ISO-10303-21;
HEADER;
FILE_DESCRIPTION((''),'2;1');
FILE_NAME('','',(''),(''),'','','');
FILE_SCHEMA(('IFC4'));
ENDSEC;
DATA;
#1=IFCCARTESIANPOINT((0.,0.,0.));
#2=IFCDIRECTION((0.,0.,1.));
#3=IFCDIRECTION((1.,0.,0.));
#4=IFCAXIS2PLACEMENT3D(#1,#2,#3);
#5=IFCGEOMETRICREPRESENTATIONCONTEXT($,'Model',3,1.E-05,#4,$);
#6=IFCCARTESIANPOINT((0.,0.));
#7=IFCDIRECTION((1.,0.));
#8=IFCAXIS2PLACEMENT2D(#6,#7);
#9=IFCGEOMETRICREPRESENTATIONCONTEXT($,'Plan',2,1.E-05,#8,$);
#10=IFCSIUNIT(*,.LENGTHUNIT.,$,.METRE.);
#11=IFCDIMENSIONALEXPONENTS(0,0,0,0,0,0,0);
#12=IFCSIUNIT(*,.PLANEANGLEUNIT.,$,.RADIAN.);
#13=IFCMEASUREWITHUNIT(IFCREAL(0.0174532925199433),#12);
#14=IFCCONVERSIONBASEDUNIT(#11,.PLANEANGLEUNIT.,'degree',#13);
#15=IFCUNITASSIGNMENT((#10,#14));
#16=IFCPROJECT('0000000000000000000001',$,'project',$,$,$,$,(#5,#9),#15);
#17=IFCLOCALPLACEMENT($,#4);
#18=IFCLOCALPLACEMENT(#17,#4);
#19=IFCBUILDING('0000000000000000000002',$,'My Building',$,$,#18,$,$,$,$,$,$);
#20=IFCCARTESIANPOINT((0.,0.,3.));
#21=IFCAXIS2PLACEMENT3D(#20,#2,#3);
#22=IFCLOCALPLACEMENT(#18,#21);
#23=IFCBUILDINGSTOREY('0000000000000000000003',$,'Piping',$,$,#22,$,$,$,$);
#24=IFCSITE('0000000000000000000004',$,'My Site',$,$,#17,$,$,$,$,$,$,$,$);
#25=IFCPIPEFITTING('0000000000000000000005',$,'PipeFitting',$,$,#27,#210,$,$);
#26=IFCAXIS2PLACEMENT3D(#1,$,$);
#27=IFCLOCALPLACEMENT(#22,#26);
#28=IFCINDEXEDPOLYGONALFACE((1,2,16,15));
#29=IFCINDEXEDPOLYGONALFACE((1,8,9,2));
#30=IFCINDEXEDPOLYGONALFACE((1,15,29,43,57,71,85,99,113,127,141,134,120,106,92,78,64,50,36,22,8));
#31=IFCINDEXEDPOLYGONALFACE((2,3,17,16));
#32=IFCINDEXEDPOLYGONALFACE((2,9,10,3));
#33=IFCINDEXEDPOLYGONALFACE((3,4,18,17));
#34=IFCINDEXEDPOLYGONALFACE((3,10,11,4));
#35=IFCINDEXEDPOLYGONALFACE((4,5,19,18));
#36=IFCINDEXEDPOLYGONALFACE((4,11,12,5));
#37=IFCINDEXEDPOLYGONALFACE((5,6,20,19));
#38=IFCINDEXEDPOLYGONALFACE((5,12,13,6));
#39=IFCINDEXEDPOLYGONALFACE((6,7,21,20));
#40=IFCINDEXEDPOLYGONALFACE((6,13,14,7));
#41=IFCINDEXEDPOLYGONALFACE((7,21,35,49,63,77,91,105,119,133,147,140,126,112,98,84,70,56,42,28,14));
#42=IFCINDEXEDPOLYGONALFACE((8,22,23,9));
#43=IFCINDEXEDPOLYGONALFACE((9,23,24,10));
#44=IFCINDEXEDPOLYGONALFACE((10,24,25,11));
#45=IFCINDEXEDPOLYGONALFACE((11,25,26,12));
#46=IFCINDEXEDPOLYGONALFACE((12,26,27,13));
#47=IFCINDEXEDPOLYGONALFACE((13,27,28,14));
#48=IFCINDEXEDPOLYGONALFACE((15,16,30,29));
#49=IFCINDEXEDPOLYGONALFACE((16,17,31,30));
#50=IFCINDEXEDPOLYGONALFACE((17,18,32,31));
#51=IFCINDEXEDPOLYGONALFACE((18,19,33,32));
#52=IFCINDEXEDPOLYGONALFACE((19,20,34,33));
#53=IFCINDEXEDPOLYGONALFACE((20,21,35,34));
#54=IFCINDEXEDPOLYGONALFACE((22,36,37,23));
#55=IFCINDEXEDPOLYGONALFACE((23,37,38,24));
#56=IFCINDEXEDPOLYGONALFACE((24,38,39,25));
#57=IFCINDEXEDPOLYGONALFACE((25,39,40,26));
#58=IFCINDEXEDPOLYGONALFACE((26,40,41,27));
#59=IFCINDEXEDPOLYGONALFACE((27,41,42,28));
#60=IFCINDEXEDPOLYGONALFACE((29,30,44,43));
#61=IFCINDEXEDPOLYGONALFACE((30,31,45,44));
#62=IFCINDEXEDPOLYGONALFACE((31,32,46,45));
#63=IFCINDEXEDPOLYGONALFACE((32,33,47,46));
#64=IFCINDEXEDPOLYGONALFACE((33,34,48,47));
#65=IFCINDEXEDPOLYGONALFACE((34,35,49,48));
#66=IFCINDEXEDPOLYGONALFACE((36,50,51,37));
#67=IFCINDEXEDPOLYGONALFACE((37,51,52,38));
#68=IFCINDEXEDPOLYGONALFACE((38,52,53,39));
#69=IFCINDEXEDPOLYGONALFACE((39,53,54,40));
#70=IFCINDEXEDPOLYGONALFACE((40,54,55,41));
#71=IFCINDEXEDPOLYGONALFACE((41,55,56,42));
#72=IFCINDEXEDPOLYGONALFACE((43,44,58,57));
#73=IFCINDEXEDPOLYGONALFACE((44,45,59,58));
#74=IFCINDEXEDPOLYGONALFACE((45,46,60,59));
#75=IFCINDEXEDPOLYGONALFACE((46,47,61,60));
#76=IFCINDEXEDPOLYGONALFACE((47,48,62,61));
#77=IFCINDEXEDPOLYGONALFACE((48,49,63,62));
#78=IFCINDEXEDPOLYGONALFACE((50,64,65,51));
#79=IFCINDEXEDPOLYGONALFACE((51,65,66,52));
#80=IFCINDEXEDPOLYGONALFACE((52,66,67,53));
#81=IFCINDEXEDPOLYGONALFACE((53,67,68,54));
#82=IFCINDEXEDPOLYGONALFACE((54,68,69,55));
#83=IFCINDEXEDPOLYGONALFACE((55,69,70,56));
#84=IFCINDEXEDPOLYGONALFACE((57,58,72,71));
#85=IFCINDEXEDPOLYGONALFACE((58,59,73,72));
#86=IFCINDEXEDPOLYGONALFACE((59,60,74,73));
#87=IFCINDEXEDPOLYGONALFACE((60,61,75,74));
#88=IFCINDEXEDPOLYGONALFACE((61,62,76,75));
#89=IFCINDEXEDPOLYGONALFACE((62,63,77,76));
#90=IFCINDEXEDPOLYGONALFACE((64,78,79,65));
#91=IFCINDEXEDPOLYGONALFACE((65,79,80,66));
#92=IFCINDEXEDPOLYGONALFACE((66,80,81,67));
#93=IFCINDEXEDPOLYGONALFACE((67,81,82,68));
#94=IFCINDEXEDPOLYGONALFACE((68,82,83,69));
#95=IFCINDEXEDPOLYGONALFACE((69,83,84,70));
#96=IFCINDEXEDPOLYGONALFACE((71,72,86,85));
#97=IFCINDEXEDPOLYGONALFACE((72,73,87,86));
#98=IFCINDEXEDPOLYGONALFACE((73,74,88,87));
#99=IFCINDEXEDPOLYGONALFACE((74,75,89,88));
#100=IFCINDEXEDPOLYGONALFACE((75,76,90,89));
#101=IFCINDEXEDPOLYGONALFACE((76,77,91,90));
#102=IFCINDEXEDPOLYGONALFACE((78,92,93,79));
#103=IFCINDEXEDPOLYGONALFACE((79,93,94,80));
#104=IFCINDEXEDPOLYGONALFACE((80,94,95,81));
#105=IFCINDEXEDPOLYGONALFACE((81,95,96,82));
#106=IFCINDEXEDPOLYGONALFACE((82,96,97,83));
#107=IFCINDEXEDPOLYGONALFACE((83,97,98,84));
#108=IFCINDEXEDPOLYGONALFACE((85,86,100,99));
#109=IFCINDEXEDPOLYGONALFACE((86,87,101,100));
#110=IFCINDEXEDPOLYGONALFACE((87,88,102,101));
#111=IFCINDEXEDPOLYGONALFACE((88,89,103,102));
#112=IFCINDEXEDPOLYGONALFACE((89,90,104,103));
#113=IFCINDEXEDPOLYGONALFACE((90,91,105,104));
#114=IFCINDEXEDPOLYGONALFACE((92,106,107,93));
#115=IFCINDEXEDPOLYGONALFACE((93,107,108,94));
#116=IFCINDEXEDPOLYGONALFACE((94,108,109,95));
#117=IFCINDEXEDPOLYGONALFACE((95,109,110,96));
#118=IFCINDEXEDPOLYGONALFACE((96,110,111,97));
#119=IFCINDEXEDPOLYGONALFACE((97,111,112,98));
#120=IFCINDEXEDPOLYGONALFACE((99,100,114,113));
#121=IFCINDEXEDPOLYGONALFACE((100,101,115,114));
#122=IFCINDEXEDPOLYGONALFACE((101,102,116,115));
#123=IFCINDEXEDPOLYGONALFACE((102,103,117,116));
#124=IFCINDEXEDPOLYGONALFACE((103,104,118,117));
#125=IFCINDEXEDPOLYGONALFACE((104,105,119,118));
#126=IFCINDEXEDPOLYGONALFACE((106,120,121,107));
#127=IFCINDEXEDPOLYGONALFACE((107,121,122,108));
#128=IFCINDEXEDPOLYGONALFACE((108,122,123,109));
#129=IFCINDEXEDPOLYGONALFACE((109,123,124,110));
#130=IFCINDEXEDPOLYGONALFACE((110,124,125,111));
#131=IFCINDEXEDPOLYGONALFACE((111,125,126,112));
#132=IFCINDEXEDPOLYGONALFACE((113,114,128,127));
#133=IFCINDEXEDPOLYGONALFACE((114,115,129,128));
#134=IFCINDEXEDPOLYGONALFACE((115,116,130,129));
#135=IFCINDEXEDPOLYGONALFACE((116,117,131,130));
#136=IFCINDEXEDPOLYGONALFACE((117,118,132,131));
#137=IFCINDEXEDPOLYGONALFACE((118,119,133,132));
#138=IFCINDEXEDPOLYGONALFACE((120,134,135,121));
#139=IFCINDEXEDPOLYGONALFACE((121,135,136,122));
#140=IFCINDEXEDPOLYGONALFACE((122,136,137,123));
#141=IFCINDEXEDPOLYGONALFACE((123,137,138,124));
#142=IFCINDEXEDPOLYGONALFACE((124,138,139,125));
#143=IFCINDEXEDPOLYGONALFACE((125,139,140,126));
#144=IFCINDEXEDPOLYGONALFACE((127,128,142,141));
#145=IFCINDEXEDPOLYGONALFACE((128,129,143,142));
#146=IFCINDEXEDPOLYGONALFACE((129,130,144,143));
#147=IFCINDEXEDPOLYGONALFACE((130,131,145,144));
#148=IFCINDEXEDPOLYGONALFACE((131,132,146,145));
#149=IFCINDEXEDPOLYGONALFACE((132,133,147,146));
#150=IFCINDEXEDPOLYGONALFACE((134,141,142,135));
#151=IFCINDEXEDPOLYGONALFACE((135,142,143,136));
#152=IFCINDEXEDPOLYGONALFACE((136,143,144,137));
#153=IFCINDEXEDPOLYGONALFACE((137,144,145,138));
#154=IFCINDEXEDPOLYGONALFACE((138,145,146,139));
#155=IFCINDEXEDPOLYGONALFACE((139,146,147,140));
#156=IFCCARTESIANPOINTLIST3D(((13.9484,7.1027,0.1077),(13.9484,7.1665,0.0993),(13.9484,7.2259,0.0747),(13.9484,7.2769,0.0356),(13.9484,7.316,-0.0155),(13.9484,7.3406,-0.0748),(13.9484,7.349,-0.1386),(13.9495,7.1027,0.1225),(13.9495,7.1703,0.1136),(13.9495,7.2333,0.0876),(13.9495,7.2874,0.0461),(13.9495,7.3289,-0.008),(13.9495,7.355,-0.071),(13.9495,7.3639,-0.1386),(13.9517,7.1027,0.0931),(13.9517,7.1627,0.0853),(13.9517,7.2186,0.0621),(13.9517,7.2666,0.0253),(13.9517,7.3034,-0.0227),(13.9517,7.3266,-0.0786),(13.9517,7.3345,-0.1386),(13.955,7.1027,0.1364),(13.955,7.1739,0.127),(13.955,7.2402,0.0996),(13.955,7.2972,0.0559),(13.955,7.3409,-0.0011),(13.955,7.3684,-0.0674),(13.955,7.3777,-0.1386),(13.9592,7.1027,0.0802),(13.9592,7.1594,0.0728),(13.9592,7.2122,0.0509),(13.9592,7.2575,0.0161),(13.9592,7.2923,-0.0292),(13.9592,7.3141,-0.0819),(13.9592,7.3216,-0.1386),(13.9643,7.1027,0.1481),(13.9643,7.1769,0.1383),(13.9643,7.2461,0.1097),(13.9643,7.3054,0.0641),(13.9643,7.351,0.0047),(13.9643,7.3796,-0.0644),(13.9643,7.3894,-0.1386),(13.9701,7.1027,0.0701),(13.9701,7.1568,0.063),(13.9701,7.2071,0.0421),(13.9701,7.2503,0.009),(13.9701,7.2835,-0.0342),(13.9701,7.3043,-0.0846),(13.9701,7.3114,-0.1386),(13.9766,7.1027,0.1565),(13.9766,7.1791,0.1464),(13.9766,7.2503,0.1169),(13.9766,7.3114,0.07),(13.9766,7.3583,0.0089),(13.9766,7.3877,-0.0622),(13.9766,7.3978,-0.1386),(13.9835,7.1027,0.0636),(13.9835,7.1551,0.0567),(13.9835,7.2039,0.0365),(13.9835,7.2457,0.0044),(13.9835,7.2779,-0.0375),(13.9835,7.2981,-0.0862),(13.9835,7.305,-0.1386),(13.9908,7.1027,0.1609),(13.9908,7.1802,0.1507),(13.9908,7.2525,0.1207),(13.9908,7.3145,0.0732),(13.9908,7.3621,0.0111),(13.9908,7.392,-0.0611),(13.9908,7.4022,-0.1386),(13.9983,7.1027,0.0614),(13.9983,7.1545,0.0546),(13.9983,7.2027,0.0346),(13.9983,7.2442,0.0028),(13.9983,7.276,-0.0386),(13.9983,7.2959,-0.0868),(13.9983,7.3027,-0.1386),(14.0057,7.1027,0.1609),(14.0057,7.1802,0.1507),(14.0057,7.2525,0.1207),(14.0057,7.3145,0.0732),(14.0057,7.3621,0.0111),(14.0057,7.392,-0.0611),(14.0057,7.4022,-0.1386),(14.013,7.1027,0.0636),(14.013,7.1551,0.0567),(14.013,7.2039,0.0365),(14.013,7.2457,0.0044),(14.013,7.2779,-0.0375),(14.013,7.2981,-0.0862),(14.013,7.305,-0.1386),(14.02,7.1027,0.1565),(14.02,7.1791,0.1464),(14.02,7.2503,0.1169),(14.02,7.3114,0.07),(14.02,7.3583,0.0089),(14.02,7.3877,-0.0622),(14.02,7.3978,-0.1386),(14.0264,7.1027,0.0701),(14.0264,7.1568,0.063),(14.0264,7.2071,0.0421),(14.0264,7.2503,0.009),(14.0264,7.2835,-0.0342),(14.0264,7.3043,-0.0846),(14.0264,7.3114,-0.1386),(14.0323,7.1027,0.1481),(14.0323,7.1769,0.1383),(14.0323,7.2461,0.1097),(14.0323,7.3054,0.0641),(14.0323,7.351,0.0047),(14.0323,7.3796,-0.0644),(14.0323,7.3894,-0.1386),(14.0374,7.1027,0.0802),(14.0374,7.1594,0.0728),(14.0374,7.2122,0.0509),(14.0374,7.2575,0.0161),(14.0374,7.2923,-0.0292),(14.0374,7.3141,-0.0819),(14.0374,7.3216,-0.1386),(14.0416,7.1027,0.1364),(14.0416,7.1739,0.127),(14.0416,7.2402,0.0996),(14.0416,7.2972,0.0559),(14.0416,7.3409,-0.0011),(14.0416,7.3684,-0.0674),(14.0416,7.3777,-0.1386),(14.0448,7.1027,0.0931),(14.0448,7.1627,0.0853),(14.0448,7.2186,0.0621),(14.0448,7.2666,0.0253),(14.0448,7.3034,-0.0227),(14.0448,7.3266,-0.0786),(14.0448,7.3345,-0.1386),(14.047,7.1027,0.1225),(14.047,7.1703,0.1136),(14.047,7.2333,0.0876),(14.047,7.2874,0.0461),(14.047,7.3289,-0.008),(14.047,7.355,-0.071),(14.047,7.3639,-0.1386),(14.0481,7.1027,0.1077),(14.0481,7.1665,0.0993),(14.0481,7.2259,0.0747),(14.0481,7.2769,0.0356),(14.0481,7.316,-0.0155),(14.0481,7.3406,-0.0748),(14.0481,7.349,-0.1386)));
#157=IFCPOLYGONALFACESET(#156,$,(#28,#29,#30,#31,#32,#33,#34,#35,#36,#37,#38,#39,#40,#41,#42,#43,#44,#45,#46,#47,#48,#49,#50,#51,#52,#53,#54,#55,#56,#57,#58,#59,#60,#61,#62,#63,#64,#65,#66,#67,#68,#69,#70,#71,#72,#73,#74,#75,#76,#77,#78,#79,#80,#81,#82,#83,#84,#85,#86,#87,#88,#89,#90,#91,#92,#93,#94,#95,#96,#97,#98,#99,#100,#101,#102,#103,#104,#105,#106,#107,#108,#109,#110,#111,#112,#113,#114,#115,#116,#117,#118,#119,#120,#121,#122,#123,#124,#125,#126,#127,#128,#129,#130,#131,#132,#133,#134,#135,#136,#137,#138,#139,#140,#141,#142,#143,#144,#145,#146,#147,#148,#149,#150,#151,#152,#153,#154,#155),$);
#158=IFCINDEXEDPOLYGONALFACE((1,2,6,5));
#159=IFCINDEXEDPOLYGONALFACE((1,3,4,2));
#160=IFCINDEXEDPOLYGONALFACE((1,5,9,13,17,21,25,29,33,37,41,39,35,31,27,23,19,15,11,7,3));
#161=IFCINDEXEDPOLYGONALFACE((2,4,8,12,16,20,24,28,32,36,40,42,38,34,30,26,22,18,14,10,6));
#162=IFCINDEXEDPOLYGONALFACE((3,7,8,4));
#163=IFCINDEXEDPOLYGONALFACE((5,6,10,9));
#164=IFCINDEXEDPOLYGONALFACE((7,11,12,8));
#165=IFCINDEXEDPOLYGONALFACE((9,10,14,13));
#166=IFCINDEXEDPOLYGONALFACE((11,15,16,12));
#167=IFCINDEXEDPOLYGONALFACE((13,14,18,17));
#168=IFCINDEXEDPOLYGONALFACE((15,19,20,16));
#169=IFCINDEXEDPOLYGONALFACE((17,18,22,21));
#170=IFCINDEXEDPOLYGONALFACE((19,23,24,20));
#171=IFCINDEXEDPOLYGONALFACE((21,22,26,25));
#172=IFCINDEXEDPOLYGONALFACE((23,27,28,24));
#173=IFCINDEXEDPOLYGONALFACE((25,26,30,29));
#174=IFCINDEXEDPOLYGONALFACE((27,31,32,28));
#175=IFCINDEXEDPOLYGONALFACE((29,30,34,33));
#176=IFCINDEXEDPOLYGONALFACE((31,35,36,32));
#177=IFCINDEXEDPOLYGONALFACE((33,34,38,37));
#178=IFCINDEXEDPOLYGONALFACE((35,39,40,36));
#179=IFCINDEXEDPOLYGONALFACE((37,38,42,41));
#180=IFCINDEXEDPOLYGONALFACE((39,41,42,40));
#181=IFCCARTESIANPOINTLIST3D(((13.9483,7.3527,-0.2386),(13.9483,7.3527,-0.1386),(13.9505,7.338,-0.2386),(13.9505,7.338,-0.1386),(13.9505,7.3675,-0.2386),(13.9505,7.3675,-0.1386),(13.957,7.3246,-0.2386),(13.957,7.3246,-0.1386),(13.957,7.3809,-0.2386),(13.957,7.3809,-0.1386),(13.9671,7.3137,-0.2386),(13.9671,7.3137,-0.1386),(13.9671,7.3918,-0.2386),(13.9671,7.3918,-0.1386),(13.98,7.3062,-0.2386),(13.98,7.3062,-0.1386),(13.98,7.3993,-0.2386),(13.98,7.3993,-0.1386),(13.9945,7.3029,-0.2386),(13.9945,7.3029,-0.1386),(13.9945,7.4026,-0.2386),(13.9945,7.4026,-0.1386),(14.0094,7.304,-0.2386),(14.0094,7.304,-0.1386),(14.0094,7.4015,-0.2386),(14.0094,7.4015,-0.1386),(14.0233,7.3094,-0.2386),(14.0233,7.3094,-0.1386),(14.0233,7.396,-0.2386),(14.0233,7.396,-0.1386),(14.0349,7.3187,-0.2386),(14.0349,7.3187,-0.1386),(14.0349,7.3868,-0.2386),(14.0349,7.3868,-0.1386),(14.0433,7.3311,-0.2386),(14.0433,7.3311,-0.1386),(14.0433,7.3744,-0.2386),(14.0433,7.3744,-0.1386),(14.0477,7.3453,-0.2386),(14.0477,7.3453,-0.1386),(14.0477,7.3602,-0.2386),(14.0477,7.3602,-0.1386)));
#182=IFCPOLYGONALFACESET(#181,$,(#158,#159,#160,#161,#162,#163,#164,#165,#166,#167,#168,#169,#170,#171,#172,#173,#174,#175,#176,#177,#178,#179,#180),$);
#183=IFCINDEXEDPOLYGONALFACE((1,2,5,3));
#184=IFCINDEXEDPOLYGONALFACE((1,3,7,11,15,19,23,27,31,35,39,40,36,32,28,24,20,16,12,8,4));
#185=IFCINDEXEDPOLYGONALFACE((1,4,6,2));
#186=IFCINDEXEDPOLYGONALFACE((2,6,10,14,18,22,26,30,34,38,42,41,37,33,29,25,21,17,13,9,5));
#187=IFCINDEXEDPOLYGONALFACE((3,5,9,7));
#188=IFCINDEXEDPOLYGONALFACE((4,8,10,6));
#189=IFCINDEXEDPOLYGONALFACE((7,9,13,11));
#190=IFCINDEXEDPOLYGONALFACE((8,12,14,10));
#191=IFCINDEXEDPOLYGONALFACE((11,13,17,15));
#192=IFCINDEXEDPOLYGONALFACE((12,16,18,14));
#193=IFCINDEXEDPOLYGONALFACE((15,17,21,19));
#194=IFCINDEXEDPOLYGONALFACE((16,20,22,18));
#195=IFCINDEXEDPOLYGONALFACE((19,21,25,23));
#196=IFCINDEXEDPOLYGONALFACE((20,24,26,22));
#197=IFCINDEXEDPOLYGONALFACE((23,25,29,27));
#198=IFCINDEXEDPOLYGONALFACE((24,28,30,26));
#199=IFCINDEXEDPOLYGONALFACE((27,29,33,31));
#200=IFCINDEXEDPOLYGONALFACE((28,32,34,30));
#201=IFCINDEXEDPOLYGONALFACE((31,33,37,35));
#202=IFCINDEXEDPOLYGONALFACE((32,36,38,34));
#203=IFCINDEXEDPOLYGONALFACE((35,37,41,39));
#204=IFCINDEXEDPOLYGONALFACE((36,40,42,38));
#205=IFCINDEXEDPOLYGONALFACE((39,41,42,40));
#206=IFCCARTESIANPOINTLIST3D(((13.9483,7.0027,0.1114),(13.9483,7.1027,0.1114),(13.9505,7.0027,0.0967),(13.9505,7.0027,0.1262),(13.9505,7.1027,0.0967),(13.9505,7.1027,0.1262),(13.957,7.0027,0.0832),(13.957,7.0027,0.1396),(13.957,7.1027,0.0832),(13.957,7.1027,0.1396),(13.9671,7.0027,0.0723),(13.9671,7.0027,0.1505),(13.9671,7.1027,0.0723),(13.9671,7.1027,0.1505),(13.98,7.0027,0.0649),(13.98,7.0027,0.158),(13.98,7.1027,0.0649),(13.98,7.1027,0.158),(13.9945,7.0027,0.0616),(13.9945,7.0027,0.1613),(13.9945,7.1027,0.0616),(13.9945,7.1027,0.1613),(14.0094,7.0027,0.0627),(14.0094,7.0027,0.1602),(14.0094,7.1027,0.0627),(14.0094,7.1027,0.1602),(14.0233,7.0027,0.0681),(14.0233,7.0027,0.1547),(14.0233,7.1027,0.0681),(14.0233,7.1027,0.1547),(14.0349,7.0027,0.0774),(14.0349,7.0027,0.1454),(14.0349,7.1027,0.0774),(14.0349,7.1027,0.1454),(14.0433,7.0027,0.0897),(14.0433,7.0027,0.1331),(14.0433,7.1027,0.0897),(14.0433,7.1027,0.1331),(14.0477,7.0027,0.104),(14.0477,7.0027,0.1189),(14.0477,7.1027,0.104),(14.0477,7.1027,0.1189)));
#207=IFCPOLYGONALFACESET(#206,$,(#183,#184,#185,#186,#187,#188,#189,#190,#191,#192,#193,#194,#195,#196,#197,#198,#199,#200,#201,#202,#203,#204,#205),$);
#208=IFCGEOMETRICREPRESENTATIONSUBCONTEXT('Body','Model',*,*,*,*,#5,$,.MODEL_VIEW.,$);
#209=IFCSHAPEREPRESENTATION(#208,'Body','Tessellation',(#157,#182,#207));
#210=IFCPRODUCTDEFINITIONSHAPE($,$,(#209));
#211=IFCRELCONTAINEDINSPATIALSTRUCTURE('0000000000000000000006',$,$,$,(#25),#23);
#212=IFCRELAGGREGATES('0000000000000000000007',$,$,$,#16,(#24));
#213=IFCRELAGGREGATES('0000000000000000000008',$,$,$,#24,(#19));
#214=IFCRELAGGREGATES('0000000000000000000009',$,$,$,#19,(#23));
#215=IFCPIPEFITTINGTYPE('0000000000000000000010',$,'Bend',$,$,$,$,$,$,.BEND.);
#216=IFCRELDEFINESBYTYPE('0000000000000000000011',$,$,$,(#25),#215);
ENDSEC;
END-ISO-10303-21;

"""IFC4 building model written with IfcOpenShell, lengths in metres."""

from ifc_helpers import new_model, entity, si_unit, converted_unit, frame, origin_with_axes, origin_2d_with_axis, place, context, subcontext, project, spatial, circle, extrude, source, transform, mapped, type_object, type_shapes, element, save


model = new_model("IFC4")

# Units and contexts
model_context = context("Model", 3, precision=1e-05, world=origin_with_axes())
plan_context = context("Plan", 2, precision=1e-05, world=origin_2d_with_axis())
body_context = subcontext(model_context, "Body", "Model", "MODEL_VIEW")
ifc_project = project(units=[si_unit("LENGTHUNIT", "METRE"), converted_unit("PLANEANGLEUNIT", "degree", entity("IfcReal", 0.0174532925199433), si_unit("PLANEANGLEUNIT", "RADIAN"), dimensions=[0, 0, 0, 0, 0, 0, 0])], contexts=[model_context, plan_context])

# Site, building, storey
site_placement = place(None, origin_with_axes())
site = spatial("IfcSite", under=ifc_project, at=site_placement, Name="My Site")
building_placement = place(site_placement, origin_with_axes())
building = spatial("IfcBuilding", under=site, at=building_placement, Name="My Building")
storey_placement = place(building_placement, frame((0.0, 0.0, 3.0), z_axis=(0.0, 0.0, 1.0), x_axis=(1.0, 0.0, 0.0)))
storey = spatial("IfcBuildingStorey", under=building, at=storey_placement, Name="Piping")

# Pipe fitting
pipe_fitting_type_1 = type_object("IfcPipeFittingType", Name="Bend", PredefinedType="BEND")
shared_shape = source(origin_with_axes(), body_context, "Body", "SolidModel", [
    entity("IfcSweptDiskSolid", entity("IfcIndexedPolyCurve", entity("IfcCartesianPointList3D", [[0.0, 0.0, -0.1], [0.0, -0.0732, -0.2768], [0.0, -0.25, -0.35]]), [entity("IfcArcIndex", [1, 2, 3])]), 0.05),
    extrude(circle(Radius=0.05), origin_with_axes(), (0.0, 0.0, -1.0), 0.1),
    extrude(circle(Radius=0.05), frame((0.0, -0.25, -0.35), z_axis=(0.0, -1.0, 0.0), x_axis=(1.0, 0.0, 0.0)), (0.0, 0.0, 1.0), 0.1),
])
type_shapes(pipe_fitting_type_1, [shared_shape])
for number, where, z_axis, x_axis, name in (
    (1, (13.9983, 7.3527, -0.2386), (0.0, 0.0, -1.0), (-1.0, 0.0, 0.0), "PipeFitting"),
):
    element("IfcPipeFitting", number, at=place(storey_placement, frame(where, z_axis=z_axis, x_axis=x_axis)), inside=storey, type_object=pipe_fitting_type_1, Name=name, context=body_context, shape_type="MappedRepresentation", body=[
        mapped(shared_shape, transform((0.0, 0.0, 0.0), x_axis=(1.0, 0.0, 0.0), y_axis=(0.0, 1.0, 0.0), z_axis=(0.0, 0.0, 1.0), scale=1.0)),
    ])

save(model, "model.ifc")
